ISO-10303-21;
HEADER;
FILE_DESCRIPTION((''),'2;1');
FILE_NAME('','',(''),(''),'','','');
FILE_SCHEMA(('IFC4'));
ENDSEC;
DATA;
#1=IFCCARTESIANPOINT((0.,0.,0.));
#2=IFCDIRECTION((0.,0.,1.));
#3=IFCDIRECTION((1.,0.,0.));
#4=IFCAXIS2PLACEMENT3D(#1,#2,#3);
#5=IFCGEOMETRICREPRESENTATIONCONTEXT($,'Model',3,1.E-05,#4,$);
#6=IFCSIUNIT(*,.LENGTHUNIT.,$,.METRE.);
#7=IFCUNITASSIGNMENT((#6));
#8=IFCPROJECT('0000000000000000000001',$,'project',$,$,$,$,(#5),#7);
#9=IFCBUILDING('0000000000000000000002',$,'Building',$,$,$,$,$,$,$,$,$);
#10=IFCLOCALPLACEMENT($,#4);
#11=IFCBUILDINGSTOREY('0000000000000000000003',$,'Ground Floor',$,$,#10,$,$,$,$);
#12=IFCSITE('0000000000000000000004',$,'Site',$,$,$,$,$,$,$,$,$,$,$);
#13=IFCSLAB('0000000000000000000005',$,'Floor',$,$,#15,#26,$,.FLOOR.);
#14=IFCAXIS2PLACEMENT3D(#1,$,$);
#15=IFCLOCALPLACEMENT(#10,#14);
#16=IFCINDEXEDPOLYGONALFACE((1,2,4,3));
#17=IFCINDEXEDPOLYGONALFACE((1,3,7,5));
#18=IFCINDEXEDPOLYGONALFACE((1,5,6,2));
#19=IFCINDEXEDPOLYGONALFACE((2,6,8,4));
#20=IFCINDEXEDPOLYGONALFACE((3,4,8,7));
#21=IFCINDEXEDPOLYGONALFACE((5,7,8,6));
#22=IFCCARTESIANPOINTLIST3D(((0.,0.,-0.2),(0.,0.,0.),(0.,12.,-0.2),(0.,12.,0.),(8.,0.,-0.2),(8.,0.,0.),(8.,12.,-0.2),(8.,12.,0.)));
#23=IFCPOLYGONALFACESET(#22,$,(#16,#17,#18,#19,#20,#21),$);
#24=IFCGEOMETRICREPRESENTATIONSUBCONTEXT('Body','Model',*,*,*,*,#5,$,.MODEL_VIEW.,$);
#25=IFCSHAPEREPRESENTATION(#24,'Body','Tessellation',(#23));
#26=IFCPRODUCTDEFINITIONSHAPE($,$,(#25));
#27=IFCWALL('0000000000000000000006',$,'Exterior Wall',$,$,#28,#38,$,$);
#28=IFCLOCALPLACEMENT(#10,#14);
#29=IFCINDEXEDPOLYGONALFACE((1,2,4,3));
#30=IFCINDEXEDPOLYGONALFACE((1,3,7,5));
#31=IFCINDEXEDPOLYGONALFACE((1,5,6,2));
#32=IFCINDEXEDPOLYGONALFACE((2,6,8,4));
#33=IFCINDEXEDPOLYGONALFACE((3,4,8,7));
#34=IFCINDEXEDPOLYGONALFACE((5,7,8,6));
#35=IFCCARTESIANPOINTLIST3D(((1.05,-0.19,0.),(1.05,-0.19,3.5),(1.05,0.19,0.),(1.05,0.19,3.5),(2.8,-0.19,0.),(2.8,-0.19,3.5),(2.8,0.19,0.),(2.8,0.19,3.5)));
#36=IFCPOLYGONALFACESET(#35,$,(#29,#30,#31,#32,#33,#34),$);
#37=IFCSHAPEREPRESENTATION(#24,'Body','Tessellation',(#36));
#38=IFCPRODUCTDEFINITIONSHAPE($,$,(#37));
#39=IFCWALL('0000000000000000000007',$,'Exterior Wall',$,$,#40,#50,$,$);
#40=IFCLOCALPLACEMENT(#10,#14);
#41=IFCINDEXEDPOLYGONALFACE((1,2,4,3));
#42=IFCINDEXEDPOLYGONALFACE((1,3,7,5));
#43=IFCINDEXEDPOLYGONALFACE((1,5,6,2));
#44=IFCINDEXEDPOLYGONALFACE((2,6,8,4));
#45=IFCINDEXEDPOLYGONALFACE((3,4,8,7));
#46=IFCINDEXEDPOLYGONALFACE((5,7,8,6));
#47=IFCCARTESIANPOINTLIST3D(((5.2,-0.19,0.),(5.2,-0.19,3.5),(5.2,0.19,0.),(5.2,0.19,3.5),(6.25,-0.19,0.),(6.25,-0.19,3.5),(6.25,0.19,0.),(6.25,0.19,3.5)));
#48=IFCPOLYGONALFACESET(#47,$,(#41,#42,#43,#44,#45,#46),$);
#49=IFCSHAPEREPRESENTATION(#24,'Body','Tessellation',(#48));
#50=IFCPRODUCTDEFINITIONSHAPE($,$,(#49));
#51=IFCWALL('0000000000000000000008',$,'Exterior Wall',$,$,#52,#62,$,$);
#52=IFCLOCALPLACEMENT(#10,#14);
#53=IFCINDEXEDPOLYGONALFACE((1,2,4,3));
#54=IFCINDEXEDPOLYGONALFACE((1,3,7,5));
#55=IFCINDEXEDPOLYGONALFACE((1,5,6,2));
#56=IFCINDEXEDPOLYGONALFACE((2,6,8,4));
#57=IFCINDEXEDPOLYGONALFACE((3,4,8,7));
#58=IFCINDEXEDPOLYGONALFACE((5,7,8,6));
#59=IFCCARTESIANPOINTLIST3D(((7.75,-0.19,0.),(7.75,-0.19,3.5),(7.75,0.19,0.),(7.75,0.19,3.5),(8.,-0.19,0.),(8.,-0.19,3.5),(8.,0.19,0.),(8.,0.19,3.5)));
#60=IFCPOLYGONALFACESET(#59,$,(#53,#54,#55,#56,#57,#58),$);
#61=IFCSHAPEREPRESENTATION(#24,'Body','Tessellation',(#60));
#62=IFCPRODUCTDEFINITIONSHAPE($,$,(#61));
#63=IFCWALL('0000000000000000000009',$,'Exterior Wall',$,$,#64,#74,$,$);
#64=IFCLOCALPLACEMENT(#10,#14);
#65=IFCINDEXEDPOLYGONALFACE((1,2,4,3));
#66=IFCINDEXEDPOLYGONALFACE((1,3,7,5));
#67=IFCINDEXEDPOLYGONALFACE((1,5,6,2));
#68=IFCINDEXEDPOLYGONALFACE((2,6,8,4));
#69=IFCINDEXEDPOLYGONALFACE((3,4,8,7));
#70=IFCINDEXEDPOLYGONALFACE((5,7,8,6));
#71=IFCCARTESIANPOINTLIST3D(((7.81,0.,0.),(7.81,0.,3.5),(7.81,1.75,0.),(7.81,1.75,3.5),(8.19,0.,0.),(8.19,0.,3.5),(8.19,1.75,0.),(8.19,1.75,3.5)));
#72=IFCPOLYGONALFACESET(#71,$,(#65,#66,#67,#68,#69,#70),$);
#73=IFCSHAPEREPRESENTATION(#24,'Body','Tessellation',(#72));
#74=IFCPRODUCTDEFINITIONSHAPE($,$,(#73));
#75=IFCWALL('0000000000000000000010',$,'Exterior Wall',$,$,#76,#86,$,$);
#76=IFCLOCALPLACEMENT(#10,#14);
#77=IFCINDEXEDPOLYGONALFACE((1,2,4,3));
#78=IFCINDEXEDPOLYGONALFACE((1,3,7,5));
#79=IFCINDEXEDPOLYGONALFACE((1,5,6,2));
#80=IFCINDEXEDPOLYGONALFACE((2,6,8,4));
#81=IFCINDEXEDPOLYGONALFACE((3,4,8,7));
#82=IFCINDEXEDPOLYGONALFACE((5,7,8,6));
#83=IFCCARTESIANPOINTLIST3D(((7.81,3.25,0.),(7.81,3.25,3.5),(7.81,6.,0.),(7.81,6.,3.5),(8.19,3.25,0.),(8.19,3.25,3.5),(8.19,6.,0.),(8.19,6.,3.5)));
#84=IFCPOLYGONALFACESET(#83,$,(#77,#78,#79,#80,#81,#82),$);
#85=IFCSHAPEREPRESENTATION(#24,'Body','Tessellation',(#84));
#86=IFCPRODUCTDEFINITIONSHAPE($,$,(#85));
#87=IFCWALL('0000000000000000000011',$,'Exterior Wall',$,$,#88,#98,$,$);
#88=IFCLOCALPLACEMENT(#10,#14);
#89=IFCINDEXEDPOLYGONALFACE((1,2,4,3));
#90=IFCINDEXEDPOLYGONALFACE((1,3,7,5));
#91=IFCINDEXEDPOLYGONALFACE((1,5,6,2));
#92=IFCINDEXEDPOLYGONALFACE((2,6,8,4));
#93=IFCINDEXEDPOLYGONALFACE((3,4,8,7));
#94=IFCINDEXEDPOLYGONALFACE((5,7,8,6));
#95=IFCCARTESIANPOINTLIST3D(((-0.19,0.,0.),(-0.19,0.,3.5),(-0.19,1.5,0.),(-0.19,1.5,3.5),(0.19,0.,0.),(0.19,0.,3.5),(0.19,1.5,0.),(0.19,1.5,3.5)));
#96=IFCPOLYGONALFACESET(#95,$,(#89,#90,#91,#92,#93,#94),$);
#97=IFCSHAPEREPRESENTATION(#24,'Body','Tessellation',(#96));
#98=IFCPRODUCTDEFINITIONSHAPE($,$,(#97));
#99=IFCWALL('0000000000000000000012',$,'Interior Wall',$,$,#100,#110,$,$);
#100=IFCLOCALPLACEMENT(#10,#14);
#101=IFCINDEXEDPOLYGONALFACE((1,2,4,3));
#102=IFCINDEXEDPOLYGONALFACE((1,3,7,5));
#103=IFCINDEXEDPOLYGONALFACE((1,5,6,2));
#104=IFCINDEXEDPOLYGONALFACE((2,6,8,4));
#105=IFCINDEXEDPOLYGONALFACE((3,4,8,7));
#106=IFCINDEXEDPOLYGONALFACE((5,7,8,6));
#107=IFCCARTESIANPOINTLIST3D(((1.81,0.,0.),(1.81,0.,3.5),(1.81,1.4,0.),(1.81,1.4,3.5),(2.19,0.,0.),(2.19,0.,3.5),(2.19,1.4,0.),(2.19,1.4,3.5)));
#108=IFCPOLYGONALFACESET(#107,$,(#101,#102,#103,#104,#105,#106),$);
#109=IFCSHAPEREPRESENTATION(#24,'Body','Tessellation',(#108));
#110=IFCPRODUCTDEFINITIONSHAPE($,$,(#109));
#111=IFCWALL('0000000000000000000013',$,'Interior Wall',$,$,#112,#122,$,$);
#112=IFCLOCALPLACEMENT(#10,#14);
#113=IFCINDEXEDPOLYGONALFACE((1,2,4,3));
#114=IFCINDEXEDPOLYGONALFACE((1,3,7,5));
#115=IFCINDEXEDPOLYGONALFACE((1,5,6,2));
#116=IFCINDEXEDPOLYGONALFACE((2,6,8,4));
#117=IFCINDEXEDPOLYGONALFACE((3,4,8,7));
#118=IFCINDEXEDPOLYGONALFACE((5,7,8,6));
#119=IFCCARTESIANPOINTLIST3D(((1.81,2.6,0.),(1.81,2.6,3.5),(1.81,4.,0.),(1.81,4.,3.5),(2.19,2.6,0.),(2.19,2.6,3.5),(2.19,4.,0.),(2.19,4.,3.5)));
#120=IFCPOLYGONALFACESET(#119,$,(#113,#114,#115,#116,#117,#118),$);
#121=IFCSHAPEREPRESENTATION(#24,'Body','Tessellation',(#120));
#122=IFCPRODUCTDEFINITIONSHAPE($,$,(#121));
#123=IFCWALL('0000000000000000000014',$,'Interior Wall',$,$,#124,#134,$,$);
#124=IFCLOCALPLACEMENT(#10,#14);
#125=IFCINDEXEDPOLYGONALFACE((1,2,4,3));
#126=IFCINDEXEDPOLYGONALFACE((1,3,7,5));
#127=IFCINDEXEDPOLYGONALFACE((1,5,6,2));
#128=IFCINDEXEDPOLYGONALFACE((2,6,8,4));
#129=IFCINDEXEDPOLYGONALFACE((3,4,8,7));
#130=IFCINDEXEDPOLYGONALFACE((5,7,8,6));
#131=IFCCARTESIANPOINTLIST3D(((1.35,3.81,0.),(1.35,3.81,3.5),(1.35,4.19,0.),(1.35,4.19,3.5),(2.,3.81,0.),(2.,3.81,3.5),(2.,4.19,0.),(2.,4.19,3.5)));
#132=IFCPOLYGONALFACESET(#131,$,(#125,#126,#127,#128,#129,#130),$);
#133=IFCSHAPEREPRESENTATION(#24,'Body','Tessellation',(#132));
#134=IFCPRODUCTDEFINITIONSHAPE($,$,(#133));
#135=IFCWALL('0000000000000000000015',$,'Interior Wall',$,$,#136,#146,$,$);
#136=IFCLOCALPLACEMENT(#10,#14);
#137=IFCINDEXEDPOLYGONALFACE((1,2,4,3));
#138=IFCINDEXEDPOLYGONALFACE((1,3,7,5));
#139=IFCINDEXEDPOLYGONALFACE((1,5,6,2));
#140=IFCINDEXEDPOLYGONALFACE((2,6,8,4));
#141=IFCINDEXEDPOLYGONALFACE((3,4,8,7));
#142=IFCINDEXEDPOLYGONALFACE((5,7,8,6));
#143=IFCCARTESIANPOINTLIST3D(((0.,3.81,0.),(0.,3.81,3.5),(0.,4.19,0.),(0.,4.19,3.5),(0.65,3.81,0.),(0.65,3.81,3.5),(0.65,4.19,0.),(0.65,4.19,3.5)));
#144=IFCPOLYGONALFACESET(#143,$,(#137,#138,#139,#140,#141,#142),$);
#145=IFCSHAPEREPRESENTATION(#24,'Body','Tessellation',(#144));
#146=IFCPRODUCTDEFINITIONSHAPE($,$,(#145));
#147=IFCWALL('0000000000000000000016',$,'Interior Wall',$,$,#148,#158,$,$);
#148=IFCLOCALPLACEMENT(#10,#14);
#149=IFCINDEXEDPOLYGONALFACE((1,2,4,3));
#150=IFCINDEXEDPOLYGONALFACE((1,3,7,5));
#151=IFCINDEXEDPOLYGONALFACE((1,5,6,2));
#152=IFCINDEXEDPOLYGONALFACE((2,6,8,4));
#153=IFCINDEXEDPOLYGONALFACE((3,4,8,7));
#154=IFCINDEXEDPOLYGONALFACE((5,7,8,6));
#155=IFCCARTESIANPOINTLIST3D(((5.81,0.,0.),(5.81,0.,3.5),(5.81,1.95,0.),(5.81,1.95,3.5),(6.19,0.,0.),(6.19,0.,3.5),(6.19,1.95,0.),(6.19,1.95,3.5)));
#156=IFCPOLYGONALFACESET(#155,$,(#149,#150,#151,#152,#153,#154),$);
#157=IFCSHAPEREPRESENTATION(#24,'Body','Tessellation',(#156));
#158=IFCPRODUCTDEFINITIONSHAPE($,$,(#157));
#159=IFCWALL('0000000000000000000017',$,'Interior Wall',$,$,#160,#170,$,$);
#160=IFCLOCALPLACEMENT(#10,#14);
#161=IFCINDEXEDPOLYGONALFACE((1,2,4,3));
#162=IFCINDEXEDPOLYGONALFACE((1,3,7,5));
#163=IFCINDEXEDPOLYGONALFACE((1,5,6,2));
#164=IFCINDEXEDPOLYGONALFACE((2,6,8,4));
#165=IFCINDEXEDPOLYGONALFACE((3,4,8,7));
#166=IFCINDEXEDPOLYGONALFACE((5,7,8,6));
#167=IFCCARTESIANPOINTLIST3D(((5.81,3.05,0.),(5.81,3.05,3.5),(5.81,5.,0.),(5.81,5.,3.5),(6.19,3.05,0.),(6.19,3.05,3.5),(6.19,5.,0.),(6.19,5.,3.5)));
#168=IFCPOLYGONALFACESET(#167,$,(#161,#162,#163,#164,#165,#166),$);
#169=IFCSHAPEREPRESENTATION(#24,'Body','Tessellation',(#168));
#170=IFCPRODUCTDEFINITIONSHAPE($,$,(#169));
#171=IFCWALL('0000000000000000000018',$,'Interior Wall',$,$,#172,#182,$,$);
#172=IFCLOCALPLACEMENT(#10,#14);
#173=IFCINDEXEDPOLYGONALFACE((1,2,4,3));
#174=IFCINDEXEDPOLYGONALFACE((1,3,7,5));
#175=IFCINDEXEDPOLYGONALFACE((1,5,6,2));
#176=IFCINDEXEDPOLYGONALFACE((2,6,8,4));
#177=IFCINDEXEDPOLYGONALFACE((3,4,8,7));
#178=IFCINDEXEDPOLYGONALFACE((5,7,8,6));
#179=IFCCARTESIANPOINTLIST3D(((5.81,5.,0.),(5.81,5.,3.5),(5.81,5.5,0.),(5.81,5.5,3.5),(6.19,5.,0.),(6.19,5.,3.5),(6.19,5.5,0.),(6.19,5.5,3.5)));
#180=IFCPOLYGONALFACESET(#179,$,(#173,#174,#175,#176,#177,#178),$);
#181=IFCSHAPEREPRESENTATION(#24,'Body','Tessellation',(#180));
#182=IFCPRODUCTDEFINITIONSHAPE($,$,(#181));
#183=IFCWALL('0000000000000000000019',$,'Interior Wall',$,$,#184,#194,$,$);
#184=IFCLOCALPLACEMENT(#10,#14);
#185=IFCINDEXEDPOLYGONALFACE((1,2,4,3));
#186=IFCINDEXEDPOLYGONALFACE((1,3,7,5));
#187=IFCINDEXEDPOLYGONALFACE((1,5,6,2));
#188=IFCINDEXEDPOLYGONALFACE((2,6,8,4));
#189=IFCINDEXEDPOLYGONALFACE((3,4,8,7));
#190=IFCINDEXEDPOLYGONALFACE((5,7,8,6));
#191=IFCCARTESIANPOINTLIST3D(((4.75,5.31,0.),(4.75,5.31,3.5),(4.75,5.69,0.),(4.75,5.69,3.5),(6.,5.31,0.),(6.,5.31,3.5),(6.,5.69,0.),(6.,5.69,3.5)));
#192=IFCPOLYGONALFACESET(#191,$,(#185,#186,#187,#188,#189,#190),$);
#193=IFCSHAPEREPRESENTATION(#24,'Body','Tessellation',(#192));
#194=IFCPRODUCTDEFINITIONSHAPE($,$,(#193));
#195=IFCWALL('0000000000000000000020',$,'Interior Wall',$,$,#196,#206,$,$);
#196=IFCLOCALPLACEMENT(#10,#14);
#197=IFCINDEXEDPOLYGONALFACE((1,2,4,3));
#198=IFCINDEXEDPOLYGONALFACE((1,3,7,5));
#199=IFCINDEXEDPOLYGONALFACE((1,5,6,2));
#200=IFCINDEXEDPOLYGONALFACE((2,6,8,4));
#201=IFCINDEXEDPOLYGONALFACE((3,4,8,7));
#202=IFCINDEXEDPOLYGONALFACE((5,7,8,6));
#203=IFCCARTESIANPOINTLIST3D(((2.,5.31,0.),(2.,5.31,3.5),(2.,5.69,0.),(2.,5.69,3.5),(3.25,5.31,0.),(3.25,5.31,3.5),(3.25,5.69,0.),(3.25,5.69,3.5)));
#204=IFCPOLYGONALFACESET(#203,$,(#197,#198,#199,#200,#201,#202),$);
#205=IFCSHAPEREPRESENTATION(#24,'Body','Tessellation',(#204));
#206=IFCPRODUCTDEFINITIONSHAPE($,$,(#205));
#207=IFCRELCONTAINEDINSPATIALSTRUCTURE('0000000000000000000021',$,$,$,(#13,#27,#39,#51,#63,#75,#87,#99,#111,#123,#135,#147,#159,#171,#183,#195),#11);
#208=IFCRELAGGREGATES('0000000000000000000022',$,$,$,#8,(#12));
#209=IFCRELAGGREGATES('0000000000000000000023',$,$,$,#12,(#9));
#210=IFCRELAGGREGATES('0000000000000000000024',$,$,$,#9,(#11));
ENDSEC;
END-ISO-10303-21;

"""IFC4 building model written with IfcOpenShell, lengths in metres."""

from ifc_helpers import new_model, si_unit, frame, origin_with_axes, place, context, subcontext, project, spatial, indexed_curve, outline, extrude, element, save


model = new_model("IFC4")

# Units and contexts
model_context = context("Model", 3, precision=1e-05, world=origin_with_axes())
body_context = subcontext(model_context, "Body", "Model", "MODEL_VIEW")
ifc_project = project(units=[si_unit("LENGTHUNIT", "METRE")], contexts=[model_context])

# Site, building, storey
site = spatial("IfcSite", under=ifc_project, Name="Site")
building = spatial("IfcBuilding", under=site, Name="Building")
storey_placement = place(None, origin_with_axes())
storey = spatial("IfcBuildingStorey", under=building, at=storey_placement, Name="Ground Floor")

# Slab
slab_placement = place(storey_placement, frame((0.0, 0.0, -0.2), z_axis=(0.0, 0.0, 1.0), x_axis=(1.0, 0.0, 0.0)))
element("IfcSlab", 1, at=slab_placement, inside=storey, Name="Floor", PredefinedType="FLOOR", context=body_context, shape_type="SweptSolid", body=[
    extrude(outline(indexed_curve([(0.0, 0.0), (8.0, 0.0), (8.0, 12.0), (0.0, 12.0)])), None, (0.0, 0.0, 1.0), 0.2),
])

# Walls
wall_1_placement = place(storey_placement, frame((1.05, 0.0, 0.0), z_axis=(0.0, 0.0, 1.0), x_axis=(1.0, 0.0, 0.0)))
element("IfcWall", 2, at=wall_1_placement, inside=storey, Name="Exterior Wall", context=body_context, shape_type="SweptSolid", body=[
    extrude(outline(indexed_curve([(0.0, 0.0), (0.0, 0.38), (1.75, 0.38), (1.75, 0.0), (0.0, 0.0)], self_intersect=False)), frame((0.0, -0.19, 0.0), z_axis=(0.0, 0.0, 1.0), x_axis=(1.0, 0.0, 0.0)), (0.0, 0.0, 1.0), 3.5),
])
wall_2_placement = place(storey_placement, frame((5.2, 0.0, 0.0), z_axis=(0.0, 0.0, 1.0), x_axis=(1.0, 0.0, 0.0)))
element("IfcWall", 3, at=wall_2_placement, inside=storey, Name="Exterior Wall", context=body_context, shape_type="SweptSolid", body=[
    extrude(outline(indexed_curve([(0.0, 0.0), (0.0, 0.38), (1.05, 0.38), (1.05, 0.0), (0.0, 0.0)], self_intersect=False)), frame((0.0, -0.19, 0.0), z_axis=(0.0, 0.0, 1.0), x_axis=(1.0, 0.0, 0.0)), (0.0, 0.0, 1.0), 3.5),
])
wall_3_placement = place(storey_placement, frame((7.75, 0.0, 0.0), z_axis=(0.0, 0.0, 1.0), x_axis=(1.0, 0.0, 0.0)))
element("IfcWall", 4, at=wall_3_placement, inside=storey, Name="Exterior Wall", context=body_context, shape_type="SweptSolid", body=[
    extrude(outline(indexed_curve([(0.0, 0.0), (0.0, 0.38), (0.25, 0.38), (0.25, 0.0), (0.0, 0.0)], self_intersect=False)), frame((0.0, -0.19, 0.0), z_axis=(0.0, 0.0, 1.0), x_axis=(1.0, 0.0, 0.0)), (0.0, 0.0, 1.0), 3.5),
])
wall_4_placement = place(storey_placement, frame((8.0, 0.0, 0.0), z_axis=(0.0, 0.0, 1.0), x_axis=(0.0, 1.0, 0.0)))
element("IfcWall", 5, at=wall_4_placement, inside=storey, Name="Exterior Wall", context=body_context, shape_type="SweptSolid", body=[
    extrude(outline(indexed_curve([(0.0, 0.0), (0.0, 0.38), (1.75, 0.38), (1.75, 0.0), (0.0, 0.0)], self_intersect=False)), frame((0.0, -0.19, 0.0), z_axis=(0.0, 0.0, 1.0), x_axis=(1.0, 0.0, 0.0)), (0.0, 0.0, 1.0), 3.5),
])
wall_5_placement = place(storey_placement, frame((8.0, 3.25, 0.0), z_axis=(0.0, 0.0, 1.0), x_axis=(0.0, 1.0, 0.0)))
element("IfcWall", 6, at=wall_5_placement, inside=storey, Name="Exterior Wall", context=body_context, shape_type="SweptSolid", body=[
    extrude(outline(indexed_curve([(0.0, 0.0), (0.0, 0.38), (2.75, 0.38), (2.75, 0.0), (0.0, 0.0)], self_intersect=False)), frame((0.0, -0.19, 0.0), z_axis=(0.0, 0.0, 1.0), x_axis=(1.0, 0.0, 0.0)), (0.0, 0.0, 1.0), 3.5),
])
wall_6_placement = place(storey_placement, frame((0.0, 1.5, 0.0), z_axis=(0.0, 0.0, 1.0), x_axis=(0.0, -1.0, 0.0)))
element("IfcWall", 7, at=wall_6_placement, inside=storey, Name="Exterior Wall", context=body_context, shape_type="SweptSolid", body=[
    extrude(outline(indexed_curve([(0.0, 0.0), (0.0, 0.38), (1.5, 0.38), (1.5, 0.0), (0.0, 0.0)], self_intersect=False)), frame((0.0, -0.19, 0.0), z_axis=(0.0, 0.0, 1.0), x_axis=(1.0, 0.0, 0.0)), (0.0, 0.0, 1.0), 3.5),
])
for number, where, z_axis, x_axis, name in (
    (8, (2.0, 0.0, 0.0), (0.0, 0.0, 1.0), (0.0, 1.0, 0.0), "Interior Wall"),
    (9, (2.0, 2.6, 0.0), (0.0, 0.0, 1.0), (0.0, 1.0, 0.0), "Interior Wall"),
):
    element("IfcWall", number, at=place(storey_placement, frame(where, z_axis=z_axis, x_axis=x_axis)), inside=storey, Name=name, context=body_context, shape_type="SweptSolid", body=[
        extrude(outline(indexed_curve([(0.0, 0.0), (0.0, 0.38), (1.4, 0.38), (1.4, 0.0), (0.0, 0.0)], self_intersect=False)), frame((0.0, -0.19, 0.0), z_axis=(0.0, 0.0, 1.0), x_axis=(1.0, 0.0, 0.0)), (0.0, 0.0, 1.0), 3.5),
    ])
for number, where, z_axis, x_axis, name in (
    (10, (2.0, 4.0, 0.0), (0.0, 0.0, 1.0), (-1.0, 0.0, 0.0), "Interior Wall"),
    (11, (0.65, 4.0, 0.0), (0.0, 0.0, 1.0), (-1.0, 0.0, 0.0), "Interior Wall"),
):
    element("IfcWall", number, at=place(storey_placement, frame(where, z_axis=z_axis, x_axis=x_axis)), inside=storey, Name=name, context=body_context, shape_type="SweptSolid", body=[
        extrude(outline(indexed_curve([(0.0, 0.0), (0.0, 0.38), (0.65, 0.38), (0.65, 0.0), (0.0, 0.0)], self_intersect=False)), frame((0.0, -0.19, 0.0), z_axis=(0.0, 0.0, 1.0), x_axis=(1.0, 0.0, 0.0)), (0.0, 0.0, 1.0), 3.5),
    ])
wall_7_placement = place(storey_placement, frame((6.0, 0.0, 0.0), z_axis=(0.0, 0.0, 1.0), x_axis=(0.0, 1.0, 0.0)))
element("IfcWall", 12, at=wall_7_placement, inside=storey, Name="Interior Wall", context=body_context, shape_type="SweptSolid", body=[
    extrude(outline(indexed_curve([(0.0, 0.0), (0.0, 0.38), (1.95, 0.38), (1.95, 0.0), (0.0, 0.0)], self_intersect=False)), frame((0.0, -0.19, 0.0), z_axis=(0.0, 0.0, 1.0), x_axis=(1.0, 0.0, 0.0)), (0.0, 0.0, 1.0), 3.5),
])
wall_8_placement = place(storey_placement, frame((6.0, 3.05, 0.0), z_axis=(0.0, 0.0, 1.0), x_axis=(0.0, 1.0, 0.0)))
element("IfcWall", 13, at=wall_8_placement, inside=storey, Name="Interior Wall", context=body_context, shape_type="SweptSolid", body=[
    extrude(outline(indexed_curve([(0.0, 0.0), (0.0, 0.38), (1.95, 0.38), (1.95, 0.0), (0.0, 0.0)], self_intersect=False)), frame((0.0, -0.19, 0.0), z_axis=(0.0, 0.0, 1.0), x_axis=(1.0, 0.0, 0.0)), (0.0, 0.0, 1.0), 3.5),
])
wall_9_placement = place(storey_placement, frame((6.0, 5.0, 0.0), z_axis=(0.0, 0.0, 1.0), x_axis=(0.0, 1.0, 0.0)))
element("IfcWall", 14, at=wall_9_placement, inside=storey, Name="Interior Wall", context=body_context, shape_type="SweptSolid", body=[
    extrude(outline(indexed_curve([(0.0, 0.0), (0.0, 0.38), (0.5, 0.38), (0.5, 0.0), (0.0, 0.0)], self_intersect=False)), frame((0.0, -0.19, 0.0), z_axis=(0.0, 0.0, 1.0), x_axis=(1.0, 0.0, 0.0)), (0.0, 0.0, 1.0), 3.5),
])
for number, where, z_axis, x_axis, name in (
    (15, (6.0, 5.5, 0.0), (0.0, 0.0, 1.0), (-1.0, 0.0, 0.0), "Interior Wall"),
    (16, (3.25, 5.5, 0.0), (0.0, 0.0, 1.0), (-1.0, 0.0, 0.0), "Interior Wall"),
):
    element("IfcWall", number, at=place(storey_placement, frame(where, z_axis=z_axis, x_axis=x_axis)), inside=storey, Name=name, context=body_context, shape_type="SweptSolid", body=[
        extrude(outline(indexed_curve([(0.0, 0.0), (0.0, 0.38), (1.25, 0.38), (1.25, 0.0), (0.0, 0.0)], self_intersect=False)), frame((0.0, -0.19, 0.0), z_axis=(0.0, 0.0, 1.0), x_axis=(1.0, 0.0, 0.0)), (0.0, 0.0, 1.0), 3.5),
    ])

save(model, "model.ifc")
